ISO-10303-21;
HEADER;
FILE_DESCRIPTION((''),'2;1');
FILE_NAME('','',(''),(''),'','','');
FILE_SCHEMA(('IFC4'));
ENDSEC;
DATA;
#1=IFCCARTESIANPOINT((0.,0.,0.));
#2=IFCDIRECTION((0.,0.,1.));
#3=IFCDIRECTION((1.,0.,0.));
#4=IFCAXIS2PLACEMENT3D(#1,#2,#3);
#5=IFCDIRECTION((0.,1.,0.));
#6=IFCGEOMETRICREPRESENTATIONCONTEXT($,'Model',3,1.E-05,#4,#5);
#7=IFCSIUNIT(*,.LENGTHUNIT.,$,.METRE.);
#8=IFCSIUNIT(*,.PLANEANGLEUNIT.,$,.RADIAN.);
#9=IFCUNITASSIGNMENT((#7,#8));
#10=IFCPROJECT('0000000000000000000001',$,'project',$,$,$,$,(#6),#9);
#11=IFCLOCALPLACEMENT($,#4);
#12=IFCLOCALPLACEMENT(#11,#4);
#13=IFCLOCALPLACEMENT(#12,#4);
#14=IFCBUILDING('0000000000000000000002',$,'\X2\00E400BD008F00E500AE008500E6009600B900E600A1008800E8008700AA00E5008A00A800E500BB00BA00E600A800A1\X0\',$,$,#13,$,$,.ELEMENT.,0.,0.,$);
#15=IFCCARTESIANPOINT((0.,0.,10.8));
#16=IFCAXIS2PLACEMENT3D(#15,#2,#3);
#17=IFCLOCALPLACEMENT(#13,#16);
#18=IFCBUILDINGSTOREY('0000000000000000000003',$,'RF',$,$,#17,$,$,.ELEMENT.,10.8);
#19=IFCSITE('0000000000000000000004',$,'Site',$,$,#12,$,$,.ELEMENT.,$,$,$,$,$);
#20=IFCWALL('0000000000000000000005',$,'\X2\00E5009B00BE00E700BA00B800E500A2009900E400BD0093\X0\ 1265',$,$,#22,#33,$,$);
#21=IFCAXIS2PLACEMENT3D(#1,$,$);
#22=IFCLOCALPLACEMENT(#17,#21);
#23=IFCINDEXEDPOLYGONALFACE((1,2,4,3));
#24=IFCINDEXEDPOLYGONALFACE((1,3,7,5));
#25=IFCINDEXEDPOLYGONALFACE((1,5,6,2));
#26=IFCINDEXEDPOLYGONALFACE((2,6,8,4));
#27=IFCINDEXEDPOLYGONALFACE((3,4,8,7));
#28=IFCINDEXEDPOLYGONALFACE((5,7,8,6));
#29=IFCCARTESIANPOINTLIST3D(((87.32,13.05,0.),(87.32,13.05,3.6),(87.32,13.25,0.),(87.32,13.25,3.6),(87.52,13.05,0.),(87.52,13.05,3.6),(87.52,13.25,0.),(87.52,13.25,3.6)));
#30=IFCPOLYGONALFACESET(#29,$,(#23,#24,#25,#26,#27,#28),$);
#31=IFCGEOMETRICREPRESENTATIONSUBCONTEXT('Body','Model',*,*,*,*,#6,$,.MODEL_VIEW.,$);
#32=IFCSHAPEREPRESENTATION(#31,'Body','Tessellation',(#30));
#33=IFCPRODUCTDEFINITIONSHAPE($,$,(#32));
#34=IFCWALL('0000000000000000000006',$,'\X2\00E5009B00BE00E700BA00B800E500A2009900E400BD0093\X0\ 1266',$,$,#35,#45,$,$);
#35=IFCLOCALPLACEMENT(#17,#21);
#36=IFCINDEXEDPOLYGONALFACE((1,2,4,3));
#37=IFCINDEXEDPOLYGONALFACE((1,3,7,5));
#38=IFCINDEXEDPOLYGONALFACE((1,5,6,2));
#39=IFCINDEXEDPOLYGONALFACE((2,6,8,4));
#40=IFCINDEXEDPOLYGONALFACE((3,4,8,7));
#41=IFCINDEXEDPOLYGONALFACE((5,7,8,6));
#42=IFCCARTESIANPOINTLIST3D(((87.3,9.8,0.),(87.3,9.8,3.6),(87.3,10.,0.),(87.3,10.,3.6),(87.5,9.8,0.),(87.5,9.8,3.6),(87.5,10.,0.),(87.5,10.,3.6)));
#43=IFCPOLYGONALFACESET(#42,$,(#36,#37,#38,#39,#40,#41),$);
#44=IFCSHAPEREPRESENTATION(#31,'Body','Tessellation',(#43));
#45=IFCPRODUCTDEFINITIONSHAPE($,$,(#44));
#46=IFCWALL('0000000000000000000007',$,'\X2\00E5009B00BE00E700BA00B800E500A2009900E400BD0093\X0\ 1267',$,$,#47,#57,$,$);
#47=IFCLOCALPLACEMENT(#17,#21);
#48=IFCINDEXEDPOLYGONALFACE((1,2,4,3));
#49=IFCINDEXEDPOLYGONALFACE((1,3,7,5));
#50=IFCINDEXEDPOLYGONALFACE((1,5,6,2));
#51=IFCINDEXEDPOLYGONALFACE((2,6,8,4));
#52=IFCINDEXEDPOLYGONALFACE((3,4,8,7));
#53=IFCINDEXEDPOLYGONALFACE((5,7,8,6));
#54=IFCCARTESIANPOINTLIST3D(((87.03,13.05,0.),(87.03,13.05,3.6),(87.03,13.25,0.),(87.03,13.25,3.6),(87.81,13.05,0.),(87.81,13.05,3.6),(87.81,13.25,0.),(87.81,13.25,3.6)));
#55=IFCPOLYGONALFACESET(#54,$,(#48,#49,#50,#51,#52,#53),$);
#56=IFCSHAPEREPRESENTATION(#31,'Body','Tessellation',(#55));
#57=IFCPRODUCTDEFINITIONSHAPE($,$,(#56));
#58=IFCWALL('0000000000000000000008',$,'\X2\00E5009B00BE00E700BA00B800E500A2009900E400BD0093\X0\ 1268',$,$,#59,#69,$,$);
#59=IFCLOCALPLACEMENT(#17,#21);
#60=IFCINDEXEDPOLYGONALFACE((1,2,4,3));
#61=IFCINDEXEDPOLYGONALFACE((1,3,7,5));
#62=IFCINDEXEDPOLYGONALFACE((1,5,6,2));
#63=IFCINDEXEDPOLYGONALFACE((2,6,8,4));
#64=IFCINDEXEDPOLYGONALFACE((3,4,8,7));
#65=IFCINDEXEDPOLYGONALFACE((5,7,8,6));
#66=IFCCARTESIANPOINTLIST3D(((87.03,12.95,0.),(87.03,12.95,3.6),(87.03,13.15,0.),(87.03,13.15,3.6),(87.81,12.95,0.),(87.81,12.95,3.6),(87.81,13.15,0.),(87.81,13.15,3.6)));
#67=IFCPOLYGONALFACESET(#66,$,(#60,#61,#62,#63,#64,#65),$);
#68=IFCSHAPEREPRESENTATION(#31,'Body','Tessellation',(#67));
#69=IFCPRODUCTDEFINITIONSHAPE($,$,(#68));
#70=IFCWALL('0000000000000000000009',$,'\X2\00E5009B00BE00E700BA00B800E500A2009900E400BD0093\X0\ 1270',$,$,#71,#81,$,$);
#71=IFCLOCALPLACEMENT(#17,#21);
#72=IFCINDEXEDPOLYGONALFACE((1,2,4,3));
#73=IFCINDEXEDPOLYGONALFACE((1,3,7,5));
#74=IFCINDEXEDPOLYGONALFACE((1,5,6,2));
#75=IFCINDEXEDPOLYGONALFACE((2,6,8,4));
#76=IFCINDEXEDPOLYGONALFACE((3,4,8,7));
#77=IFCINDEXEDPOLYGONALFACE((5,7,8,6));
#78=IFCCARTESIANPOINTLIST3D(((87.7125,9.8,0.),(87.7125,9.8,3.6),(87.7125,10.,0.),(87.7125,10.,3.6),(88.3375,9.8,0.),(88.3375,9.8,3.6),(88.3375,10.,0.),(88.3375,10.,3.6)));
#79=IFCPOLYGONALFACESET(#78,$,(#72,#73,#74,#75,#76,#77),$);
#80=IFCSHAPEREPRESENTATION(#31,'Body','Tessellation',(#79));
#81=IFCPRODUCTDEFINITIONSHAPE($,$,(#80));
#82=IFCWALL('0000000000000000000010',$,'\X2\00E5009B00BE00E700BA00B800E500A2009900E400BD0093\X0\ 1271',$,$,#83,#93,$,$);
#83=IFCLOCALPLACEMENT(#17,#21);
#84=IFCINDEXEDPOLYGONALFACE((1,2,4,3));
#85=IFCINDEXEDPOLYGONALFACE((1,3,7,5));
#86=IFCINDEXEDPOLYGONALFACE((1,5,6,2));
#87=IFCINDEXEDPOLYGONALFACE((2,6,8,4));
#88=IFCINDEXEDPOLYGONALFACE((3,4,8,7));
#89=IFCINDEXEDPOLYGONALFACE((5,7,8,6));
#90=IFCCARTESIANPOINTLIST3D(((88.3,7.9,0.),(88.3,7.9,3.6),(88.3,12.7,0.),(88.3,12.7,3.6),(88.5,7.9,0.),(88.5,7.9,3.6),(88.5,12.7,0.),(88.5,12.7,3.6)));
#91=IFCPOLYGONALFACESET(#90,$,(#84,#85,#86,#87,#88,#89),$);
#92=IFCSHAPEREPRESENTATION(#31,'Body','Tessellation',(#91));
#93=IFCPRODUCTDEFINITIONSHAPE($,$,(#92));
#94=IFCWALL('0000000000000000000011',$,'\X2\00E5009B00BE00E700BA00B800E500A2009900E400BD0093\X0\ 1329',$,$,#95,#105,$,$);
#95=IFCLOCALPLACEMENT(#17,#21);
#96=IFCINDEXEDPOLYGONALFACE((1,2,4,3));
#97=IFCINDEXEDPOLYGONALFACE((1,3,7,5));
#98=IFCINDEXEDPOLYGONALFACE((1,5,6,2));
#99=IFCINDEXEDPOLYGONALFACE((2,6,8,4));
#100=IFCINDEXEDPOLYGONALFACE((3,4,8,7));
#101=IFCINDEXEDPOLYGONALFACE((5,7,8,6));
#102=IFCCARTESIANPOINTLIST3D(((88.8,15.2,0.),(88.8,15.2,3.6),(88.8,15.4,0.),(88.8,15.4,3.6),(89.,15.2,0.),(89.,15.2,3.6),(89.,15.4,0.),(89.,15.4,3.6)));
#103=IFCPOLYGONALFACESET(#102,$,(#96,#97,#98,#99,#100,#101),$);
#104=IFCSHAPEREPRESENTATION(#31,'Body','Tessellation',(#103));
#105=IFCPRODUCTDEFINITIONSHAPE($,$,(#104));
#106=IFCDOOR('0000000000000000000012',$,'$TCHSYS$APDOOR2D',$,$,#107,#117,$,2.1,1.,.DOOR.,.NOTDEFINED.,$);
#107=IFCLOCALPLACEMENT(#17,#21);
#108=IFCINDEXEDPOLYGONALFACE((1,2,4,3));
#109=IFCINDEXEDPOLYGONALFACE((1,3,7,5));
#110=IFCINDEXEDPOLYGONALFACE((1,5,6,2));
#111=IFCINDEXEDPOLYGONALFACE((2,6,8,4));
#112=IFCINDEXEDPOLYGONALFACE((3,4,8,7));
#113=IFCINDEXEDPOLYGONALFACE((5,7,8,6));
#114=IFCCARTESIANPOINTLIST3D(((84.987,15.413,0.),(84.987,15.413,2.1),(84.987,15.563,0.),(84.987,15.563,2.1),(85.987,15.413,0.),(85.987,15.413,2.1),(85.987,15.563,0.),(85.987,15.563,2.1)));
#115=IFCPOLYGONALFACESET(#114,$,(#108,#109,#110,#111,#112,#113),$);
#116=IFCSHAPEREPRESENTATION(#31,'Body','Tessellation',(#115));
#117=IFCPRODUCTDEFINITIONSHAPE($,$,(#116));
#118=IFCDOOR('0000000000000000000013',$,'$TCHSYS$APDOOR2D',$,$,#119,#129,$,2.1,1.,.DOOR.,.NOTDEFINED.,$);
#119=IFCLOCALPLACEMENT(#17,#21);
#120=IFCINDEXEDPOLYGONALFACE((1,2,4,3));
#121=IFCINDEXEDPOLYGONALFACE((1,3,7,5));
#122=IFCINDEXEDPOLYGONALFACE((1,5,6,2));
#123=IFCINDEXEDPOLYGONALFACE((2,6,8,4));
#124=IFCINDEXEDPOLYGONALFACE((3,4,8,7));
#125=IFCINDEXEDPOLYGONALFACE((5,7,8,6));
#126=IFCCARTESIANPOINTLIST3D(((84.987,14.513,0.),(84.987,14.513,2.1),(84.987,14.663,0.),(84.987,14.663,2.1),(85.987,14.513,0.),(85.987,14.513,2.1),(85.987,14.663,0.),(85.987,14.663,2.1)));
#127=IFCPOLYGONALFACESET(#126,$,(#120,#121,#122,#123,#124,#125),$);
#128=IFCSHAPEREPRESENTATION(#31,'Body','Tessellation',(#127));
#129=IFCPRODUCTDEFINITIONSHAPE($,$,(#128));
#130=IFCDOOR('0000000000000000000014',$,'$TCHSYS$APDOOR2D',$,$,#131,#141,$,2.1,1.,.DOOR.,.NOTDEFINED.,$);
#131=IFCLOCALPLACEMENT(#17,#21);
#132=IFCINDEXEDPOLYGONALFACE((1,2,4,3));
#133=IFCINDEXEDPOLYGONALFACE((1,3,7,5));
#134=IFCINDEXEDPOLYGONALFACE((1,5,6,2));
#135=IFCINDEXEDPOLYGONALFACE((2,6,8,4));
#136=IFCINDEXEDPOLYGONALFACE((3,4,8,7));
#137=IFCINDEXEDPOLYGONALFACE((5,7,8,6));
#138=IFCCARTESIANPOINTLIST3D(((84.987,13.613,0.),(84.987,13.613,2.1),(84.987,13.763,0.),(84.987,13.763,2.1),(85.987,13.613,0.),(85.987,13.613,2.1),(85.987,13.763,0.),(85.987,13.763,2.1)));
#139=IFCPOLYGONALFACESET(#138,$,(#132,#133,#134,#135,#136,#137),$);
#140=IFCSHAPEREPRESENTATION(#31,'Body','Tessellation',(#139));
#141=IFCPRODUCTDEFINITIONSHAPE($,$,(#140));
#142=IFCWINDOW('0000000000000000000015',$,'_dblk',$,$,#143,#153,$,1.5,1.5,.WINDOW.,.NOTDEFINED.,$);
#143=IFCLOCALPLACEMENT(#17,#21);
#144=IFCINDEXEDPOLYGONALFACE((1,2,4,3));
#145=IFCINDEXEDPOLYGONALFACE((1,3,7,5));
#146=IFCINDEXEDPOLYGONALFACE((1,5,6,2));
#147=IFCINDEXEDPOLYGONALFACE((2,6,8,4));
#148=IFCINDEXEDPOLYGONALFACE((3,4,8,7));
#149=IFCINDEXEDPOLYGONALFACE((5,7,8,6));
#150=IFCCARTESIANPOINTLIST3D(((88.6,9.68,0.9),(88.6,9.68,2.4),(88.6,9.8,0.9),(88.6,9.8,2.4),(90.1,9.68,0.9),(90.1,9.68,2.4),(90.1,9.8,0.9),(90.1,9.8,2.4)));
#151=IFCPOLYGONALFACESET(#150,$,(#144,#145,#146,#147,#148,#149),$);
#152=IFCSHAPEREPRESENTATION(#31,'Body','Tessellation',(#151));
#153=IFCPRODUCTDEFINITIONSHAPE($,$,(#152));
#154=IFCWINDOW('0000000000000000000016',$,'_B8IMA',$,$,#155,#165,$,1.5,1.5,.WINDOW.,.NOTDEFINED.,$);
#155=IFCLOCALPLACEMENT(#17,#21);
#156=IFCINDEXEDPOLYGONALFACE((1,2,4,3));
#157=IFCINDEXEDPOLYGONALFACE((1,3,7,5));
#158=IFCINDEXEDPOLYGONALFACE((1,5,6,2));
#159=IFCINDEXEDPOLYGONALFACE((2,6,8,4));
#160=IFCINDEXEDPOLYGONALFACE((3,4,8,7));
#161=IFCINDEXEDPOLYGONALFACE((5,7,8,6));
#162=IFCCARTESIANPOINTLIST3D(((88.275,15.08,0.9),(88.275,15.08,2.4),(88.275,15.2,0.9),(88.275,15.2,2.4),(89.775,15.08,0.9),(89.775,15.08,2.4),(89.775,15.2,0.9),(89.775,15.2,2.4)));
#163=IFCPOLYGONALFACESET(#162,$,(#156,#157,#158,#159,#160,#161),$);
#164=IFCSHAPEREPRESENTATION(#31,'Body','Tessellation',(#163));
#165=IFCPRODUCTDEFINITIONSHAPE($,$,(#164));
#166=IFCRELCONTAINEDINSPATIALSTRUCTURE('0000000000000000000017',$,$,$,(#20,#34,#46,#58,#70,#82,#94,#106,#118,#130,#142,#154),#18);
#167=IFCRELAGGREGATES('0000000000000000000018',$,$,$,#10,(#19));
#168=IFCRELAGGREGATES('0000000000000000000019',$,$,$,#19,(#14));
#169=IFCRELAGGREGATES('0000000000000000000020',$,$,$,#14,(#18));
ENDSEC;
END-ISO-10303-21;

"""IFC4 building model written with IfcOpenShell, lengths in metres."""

from ifc_helpers import new_model, si_unit, direction, frame, frame_2d, origin_with_axes, place, context, subcontext, project, spatial, rectangle, extrude, element, save


model = new_model("IFC4")

# Units and contexts
model_context = context("Model", 3, precision=1e-05, world=origin_with_axes(), true_north=direction((0.0, 1.0, 0.0)))
body_context = subcontext(model_context, "Body", "Model", "MODEL_VIEW")
ifc_project = project(units=[si_unit("LENGTHUNIT", "METRE"), si_unit("PLANEANGLEUNIT", "RADIAN")], contexts=[model_context])

# Site, building, storey
placement = place(None, origin_with_axes())
site_placement = place(placement, origin_with_axes())
site = spatial("IfcSite", under=ifc_project, at=site_placement, Name="Site", CompositionType="ELEMENT")
building_placement = place(site_placement, origin_with_axes())
building = spatial("IfcBuilding", under=site, at=building_placement, Name="ä½\u008få®\u0085æ\u0096¹æ¡\u0088è\u0087ªå\u008a¨å»ºæ¨¡", CompositionType="ELEMENT", ElevationOfRefHeight=0.0, ElevationOfTerrain=0.0)
storey_placement = place(building_placement, frame((0.0, 0.0, 10.8), z_axis=(0.0, 0.0, 1.0), x_axis=(1.0, 0.0, 0.0)))
storey = spatial("IfcBuildingStorey", under=building, at=storey_placement, Name="RF", CompositionType="ELEMENT", Elevation=10.8)

# Walls
for number, where, z_axis, x_axis, name in (
    (1, (87.42, 13.15, 0.0), (0.0, 0.0, 1.0), (0.0, -1.0, 0.0), "å\u009b¾çº¸å¢\u0099ä½\u0093 1265"),
    (2, (87.4, 9.9, 0.0), (0.0, 0.0, 1.0), (0.0, -1.0, 0.0), "å\u009b¾çº¸å¢\u0099ä½\u0093 1266"),
):
    element("IfcWall", number, at=place(storey_placement, frame(where, z_axis=z_axis, x_axis=x_axis)), inside=storey, Name=name, context=body_context, shape_type="SweptSolid", body=[
        extrude(rectangle(XDim=0.2, YDim=0.2, at=frame_2d((0.0, 0.0), x_axis=(1.0, 0.0, 0.0))), frame((0.0, 0.0, 0.0), z_axis=(0.0, 0.0, 1.0)), (0.0, 0.0, 1.0), 3.6),
    ])
for number, where, z_axis, x_axis, name in (
    (3, (87.42, 13.15, 0.0), (0.0, 0.0, 1.0), (1.0, 0.0, 0.0), "å\u009b¾çº¸å¢\u0099ä½\u0093 1267"),
    (4, (87.42, 13.05, 0.0), (0.0, 0.0, 1.0), (1.0, 0.0, 0.0), "å\u009b¾çº¸å¢\u0099ä½\u0093 1268"),
):
    element("IfcWall", number, at=place(storey_placement, frame(where, z_axis=z_axis, x_axis=x_axis)), inside=storey, Name=name, context=body_context, shape_type="SweptSolid", body=[
        extrude(rectangle(XDim=0.78, YDim=0.2, at=frame_2d((0.0, 0.0), x_axis=(1.0, 0.0, 0.0))), frame((0.0, 0.0, 0.0), z_axis=(0.0, 0.0, 1.0)), (0.0, 0.0, 1.0), 3.6),
    ])
wall_1_placement = place(storey_placement, frame((88.025, 9.9, 0.0), z_axis=(0.0, 0.0, 1.0), x_axis=(-1.0, 0.0, 0.0)))
element("IfcWall", 5, at=wall_1_placement, inside=storey, Name="å\u009b¾çº¸å¢\u0099ä½\u0093 1270", context=body_context, shape_type="SweptSolid", body=[
    extrude(rectangle(XDim=0.625, YDim=0.2, at=frame_2d((0.0, 0.0), x_axis=(1.0, 0.0, 0.0))), frame((0.0, 0.0, 0.0), z_axis=(0.0, 0.0, 1.0)), (0.0, 0.0, 1.0), 3.6),
])
wall_2_placement = place(storey_placement, frame((88.4, 10.3, 0.0), z_axis=(0.0, 0.0, 1.0), x_axis=(0.0, 1.0, 0.0)))
element("IfcWall", 6, at=wall_2_placement, inside=storey, Name="å\u009b¾çº¸å¢\u0099ä½\u0093 1271", context=body_context, shape_type="SweptSolid", body=[
    extrude(rectangle(XDim=4.8, YDim=0.2, at=frame_2d((0.0, 0.0), x_axis=(1.0, 0.0, 0.0))), frame((0.0, 0.0, 0.0), z_axis=(0.0, 0.0, 1.0)), (0.0, 0.0, 1.0), 3.6),
])
wall_3_placement = place(storey_placement, frame((88.9, 15.3, 0.0), z_axis=(0.0, 0.0, 1.0), x_axis=(0.0, -1.0, 0.0)))
element("IfcWall", 7, at=wall_3_placement, inside=storey, Name="å\u009b¾çº¸å¢\u0099ä½\u0093 1329", context=body_context, shape_type="SweptSolid", body=[
    extrude(rectangle(XDim=0.2, YDim=0.2, at=frame_2d((0.0, 0.0), x_axis=(1.0, 0.0, 0.0))), frame((0.0, 0.0, 0.0), z_axis=(0.0, 0.0, 1.0)), (0.0, 0.0, 1.0), 3.6),
])

# Doors
for number, where, z_axis, x_axis, name in (
    (8, (85.487, 15.488, 0.0), (0.0, 0.0, 1.0), (1.0, 0.0, 0.0), "$TCHSYS$APDOOR2D"),
    (9, (85.487, 14.588, 0.0), (0.0, 0.0, 1.0), (1.0, 0.0, 0.0), "$TCHSYS$APDOOR2D"),
    (10, (85.487, 13.688, 0.0), (0.0, 0.0, 1.0), (1.0, 0.0, 0.0), "$TCHSYS$APDOOR2D"),
):
    element("IfcDoor", number, at=place(storey_placement, frame(where, z_axis=z_axis, x_axis=x_axis)), inside=storey, Name=name, OperationType="NOTDEFINED", OverallHeight=2.1, OverallWidth=1.0, PredefinedType="DOOR", context=body_context, shape_type="SweptSolid", body=[
        extrude(rectangle(XDim=1.0, YDim=0.15, at=frame_2d((0.0, 0.0), x_axis=(1.0, 0.0, 0.0))), frame((0.0, 0.0, 0.0), z_axis=(0.0, 0.0, 1.0)), (0.0, 0.0, 1.0), 2.1),
    ])

# Windows
for number, where, z_axis, x_axis, name in (
    (11, (89.35, 9.74, 0.9), (0.0, 0.0, 1.0), (1.0, 0.0, 0.0), "_dblk"),
    (12, (89.025, 15.14, 0.9), (0.0, 0.0, 1.0), (1.0, 0.0, 0.0), "_B8IMA"),
):
    element("IfcWindow", number, at=place(storey_placement, frame(where, z_axis=z_axis, x_axis=x_axis)), inside=storey, Name=name, OverallHeight=1.5, OverallWidth=1.5, PartitioningType="NOTDEFINED", PredefinedType="WINDOW", context=body_context, shape_type="SweptSolid", body=[
        extrude(rectangle(XDim=1.5, YDim=0.12, at=frame_2d((0.0, 0.0), x_axis=(1.0, 0.0, 0.0))), frame((0.0, 0.0, 0.0), z_axis=(0.0, 0.0, 1.0)), (0.0, 0.0, 1.0), 1.5),
    ])

save(model, "model.ifc")
